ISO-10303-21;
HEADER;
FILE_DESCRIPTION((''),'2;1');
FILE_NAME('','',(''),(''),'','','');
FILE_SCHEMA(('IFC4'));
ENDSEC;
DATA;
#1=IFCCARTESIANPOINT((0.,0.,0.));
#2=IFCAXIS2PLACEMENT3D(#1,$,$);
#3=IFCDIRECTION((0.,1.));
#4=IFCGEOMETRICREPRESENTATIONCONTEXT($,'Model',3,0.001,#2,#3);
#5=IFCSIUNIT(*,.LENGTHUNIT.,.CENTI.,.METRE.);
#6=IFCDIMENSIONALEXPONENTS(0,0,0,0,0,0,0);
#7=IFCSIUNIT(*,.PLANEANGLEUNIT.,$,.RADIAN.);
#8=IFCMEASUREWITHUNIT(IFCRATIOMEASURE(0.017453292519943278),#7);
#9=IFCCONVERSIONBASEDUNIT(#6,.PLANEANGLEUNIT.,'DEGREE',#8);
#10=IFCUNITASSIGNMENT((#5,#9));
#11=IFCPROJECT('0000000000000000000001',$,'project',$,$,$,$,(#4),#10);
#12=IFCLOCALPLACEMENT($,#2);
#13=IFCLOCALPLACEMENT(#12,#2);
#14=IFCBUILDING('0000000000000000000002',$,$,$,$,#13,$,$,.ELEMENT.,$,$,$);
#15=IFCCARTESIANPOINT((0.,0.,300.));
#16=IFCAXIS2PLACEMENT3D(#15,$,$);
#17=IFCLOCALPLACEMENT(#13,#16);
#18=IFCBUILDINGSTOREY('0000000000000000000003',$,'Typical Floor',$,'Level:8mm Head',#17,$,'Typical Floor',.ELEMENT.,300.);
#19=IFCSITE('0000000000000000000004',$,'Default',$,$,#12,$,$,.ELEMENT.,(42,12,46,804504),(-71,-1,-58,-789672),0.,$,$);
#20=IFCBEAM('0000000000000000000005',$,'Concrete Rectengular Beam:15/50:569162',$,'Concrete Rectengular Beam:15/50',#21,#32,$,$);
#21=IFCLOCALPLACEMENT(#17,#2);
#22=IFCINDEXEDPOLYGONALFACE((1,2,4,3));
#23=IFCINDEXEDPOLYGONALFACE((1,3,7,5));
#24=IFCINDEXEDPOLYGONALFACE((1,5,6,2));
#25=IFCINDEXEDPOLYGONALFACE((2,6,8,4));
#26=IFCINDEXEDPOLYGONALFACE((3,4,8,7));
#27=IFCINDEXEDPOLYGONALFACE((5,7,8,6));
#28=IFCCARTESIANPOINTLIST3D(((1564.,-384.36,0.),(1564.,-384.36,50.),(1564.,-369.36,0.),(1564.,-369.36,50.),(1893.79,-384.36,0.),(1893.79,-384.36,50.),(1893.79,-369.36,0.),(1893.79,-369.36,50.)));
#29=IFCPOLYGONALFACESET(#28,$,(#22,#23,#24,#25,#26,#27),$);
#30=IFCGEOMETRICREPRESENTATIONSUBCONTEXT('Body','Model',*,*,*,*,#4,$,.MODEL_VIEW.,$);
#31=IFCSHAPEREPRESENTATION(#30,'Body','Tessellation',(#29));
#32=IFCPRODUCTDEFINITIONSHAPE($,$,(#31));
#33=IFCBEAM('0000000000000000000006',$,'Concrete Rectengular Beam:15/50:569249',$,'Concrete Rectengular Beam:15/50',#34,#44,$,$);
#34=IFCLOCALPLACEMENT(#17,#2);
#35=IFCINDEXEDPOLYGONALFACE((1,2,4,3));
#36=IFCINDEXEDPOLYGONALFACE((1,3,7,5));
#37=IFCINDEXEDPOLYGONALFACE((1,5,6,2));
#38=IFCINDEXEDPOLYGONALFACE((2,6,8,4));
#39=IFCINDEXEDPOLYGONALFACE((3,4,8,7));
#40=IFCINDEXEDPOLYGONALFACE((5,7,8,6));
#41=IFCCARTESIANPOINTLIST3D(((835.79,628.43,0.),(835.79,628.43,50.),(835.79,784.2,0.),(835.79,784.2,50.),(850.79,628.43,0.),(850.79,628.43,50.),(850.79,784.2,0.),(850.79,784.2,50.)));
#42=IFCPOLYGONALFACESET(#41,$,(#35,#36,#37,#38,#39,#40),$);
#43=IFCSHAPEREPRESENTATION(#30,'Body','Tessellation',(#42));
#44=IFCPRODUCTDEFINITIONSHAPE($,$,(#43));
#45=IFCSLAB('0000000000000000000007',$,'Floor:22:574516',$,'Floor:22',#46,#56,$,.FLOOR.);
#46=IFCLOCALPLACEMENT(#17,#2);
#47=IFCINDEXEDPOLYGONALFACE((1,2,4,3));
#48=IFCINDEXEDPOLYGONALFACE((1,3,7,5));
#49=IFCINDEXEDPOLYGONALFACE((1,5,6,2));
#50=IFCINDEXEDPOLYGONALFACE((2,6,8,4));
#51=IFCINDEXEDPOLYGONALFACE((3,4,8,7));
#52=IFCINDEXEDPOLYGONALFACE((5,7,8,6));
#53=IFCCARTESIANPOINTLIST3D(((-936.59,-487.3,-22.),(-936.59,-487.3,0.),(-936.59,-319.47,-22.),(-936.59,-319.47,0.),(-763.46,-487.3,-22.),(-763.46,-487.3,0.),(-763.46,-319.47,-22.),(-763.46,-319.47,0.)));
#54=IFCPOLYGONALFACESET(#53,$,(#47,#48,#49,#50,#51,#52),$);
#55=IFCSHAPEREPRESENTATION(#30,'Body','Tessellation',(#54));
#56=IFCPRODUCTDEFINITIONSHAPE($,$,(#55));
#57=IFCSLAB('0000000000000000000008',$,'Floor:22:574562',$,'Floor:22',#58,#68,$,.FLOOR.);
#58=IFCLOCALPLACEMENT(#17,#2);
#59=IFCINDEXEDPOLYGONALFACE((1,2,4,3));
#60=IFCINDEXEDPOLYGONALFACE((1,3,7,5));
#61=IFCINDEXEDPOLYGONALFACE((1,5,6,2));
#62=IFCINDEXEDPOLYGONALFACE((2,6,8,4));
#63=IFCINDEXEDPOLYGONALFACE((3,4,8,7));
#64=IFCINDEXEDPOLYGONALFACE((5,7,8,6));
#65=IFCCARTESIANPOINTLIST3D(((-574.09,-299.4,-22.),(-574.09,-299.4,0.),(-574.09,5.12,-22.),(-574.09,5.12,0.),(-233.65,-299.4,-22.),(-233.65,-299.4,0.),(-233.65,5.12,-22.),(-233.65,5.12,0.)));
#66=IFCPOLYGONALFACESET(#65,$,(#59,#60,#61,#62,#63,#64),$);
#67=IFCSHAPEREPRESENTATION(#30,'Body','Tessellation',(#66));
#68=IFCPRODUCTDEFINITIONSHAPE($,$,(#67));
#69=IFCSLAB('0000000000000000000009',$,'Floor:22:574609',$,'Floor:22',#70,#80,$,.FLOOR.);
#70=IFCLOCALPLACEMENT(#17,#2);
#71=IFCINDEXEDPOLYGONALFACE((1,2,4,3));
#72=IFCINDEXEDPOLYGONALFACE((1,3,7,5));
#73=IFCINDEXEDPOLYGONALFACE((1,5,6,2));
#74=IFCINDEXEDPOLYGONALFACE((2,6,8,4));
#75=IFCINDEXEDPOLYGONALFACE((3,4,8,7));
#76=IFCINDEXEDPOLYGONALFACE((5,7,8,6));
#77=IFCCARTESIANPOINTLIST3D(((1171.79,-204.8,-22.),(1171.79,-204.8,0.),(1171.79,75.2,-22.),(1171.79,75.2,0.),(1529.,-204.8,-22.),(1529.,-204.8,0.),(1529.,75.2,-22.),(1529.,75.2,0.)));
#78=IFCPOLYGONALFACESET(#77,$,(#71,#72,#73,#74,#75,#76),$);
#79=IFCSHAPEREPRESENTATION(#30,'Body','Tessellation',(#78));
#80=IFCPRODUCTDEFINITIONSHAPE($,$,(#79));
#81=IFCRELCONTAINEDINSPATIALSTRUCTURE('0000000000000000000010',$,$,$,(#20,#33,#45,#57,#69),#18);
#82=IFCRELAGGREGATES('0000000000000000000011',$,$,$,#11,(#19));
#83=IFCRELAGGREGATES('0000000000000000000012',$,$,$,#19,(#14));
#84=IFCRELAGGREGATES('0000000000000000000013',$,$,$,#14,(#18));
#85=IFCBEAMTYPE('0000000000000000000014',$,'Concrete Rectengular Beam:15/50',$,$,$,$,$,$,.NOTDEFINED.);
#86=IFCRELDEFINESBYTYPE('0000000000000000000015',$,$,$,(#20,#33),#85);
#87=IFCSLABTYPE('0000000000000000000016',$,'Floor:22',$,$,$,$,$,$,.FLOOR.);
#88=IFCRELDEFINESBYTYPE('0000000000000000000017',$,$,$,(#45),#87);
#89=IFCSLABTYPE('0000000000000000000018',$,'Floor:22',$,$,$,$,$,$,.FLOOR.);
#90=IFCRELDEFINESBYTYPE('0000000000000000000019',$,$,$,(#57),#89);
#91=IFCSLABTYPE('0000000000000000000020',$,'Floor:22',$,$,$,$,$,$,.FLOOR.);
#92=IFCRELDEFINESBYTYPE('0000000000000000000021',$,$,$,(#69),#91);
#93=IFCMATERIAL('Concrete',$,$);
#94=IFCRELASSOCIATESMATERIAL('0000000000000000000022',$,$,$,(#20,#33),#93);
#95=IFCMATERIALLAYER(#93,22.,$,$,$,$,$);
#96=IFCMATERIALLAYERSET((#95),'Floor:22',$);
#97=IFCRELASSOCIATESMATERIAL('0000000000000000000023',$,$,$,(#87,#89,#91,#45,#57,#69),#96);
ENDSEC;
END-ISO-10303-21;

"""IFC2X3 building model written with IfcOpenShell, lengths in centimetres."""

from ifc_helpers import new_model, entity, si_unit, converted_unit, direction, frame, frame_2d, origin, origin_2d_with_axis, place, context, subcontext, project, spatial, rectangle, extrude, material, layer, layer_set, layer_usage, type_object, element, save


model = new_model("IFC2X3")

# Units and contexts
model_context = context("Model", 3, precision=0.001, world=origin(), true_north=direction((0.0, 1.0)))
body_context = subcontext(model_context, "Body", "Model", "MODEL_VIEW")
ifc_project = project(units=[si_unit("LENGTHUNIT", "METRE", prefix="CENTI"), converted_unit("PLANEANGLEUNIT", "DEGREE", entity("IfcRatioMeasure", 0.017453292519943278), si_unit("PLANEANGLEUNIT", "RADIAN"), dimensions=[0, 0, 0, 0, 0, 0, 0])], contexts=[model_context])

# Site, building, storey
site_placement = place(None, origin())
site = spatial("IfcSite", under=ifc_project, at=site_placement, Name="Default", CompositionType="ELEMENT", RefLatitude=(42, 12, 46, 804504), RefLongitude=(-71, -1, -58, -789672), RefElevation=0.0)
building_placement = place(site_placement, origin())
building = spatial("IfcBuilding", under=site, at=building_placement, CompositionType="ELEMENT")
storey_placement = place(building_placement, frame((0.0, 0.0, 300.0)))
storey = spatial("IfcBuildingStorey", under=building, at=storey_placement, Name="Typical Floor", ObjectType="Level:8mm Head", LongName="Typical Floor", CompositionType="ELEMENT", Elevation=300.0)

# Beams
ifc_material = material(Name="Concrete")
beam_type_1 = type_object("IfcBeamType", Name="Concrete Rectengular Beam:15/50", PredefinedType="NOTDEFINED")
beam_1_placement = place(storey_placement, frame((1564.0, -376.86, 0.0)))
element("IfcBeam", 1, at=beam_1_placement, inside=storey, type_object=beam_type_1, material=ifc_material, Name="Concrete Rectengular Beam:15/50:569162", ObjectType="Concrete Rectengular Beam:15/50", context=body_context, shape_type="SweptSolid", body=[
    extrude(rectangle(XDim=50.0, YDim=15.0, at=frame_2d((0.0, 0.0), x_axis=(1.0, 0.0))), frame((0.0, 0.0, 25.0), z_axis=(1.0, 0.0, 0.0), x_axis=(0.0, 0.0, -1.0)), (0.0, 0.0, 1.0), 329.8),
])
beam_2_placement = place(storey_placement, frame((843.29, 628.43, 0.0), z_axis=(0.0, 0.0, 1.0), x_axis=(0.0, 1.0, 0.0)))
element("IfcBeam", 2, at=beam_2_placement, inside=storey, type_object=beam_type_1, material=ifc_material, Name="Concrete Rectengular Beam:15/50:569249", ObjectType="Concrete Rectengular Beam:15/50", context=body_context, shape_type="SweptSolid", body=[
    extrude(rectangle(XDim=50.0, YDim=15.0, at=frame_2d((0.0, 0.0), x_axis=(1.0, 0.0))), frame((0.0, 0.0, 25.0), z_axis=(1.0, 0.0, 0.0), x_axis=(0.0, 0.0, -1.0)), (0.0, 0.0, 1.0), 155.77),
])

# Slabs
ifc_layer = layer(ifc_material, 22.0)
ifc_layer_set = layer_set([ifc_layer], Name="Floor:22")
ifc_layer_usage_1 = layer_usage(ifc_layer_set, "AXIS3", "POSITIVE", 0.0)
slab_type_1 = type_object("IfcSlabType", Name="Floor:22", PredefinedType="FLOOR", material=ifc_layer_set)
slab_1_placement = place(storey_placement, origin())
element("IfcSlab", 3, at=slab_1_placement, inside=storey, type_object=slab_type_1, material=ifc_layer_usage_1, Name="Floor:22:574516", ObjectType="Floor:22", PredefinedType="FLOOR", context=body_context, shape_type="SweptSolid", body=[
    extrude(rectangle(XDim=167.82, YDim=173.13, at=frame_2d((0.0, 0.0), x_axis=(1.0, 0.0))), frame((-850.03, -403.39, 0.0), z_axis=(0.0, 0.0, -1.0), x_axis=(0.0, 1.0, 0.0)), (0.0, 0.0, 1.0), 22.0),
])
ifc_layer_usage_2 = layer_usage(ifc_layer_set, "AXIS3", "POSITIVE", 0.0)
slab_type_2 = type_object("IfcSlabType", Name="Floor:22", PredefinedType="FLOOR", material=ifc_layer_set)
slab_2_placement = place(storey_placement, origin())
element("IfcSlab", 4, at=slab_2_placement, inside=storey, type_object=slab_type_2, material=ifc_layer_usage_2, Name="Floor:22:574562", ObjectType="Floor:22", PredefinedType="FLOOR", context=body_context, shape_type="SweptSolid", body=[
    extrude(rectangle(XDim=304.52, YDim=340.44, at=frame_2d((0.0, 0.0), x_axis=(1.0, 0.0))), frame((-403.87, -147.14, 0.0), z_axis=(0.0, 0.0, -1.0), x_axis=(0.0, 1.0, 0.0)), (0.0, 0.0, 1.0), 22.0),
])
ifc_layer_usage_3 = layer_usage(ifc_layer_set, "AXIS3", "POSITIVE", 0.0)
slab_type_3 = type_object("IfcSlabType", Name="Floor:22", PredefinedType="FLOOR", material=ifc_layer_set)
slab_3_placement = place(storey_placement, origin())
element("IfcSlab", 5, at=slab_3_placement, inside=storey, type_object=slab_type_3, material=ifc_layer_usage_3, Name="Floor:22:574609", ObjectType="Floor:22", PredefinedType="FLOOR", context=body_context, shape_type="SweptSolid", body=[
    extrude(rectangle(XDim=280.0, YDim=357.2, at=origin_2d_with_axis()), frame((1350.39, -64.8, 0.0), z_axis=(0.0, 0.0, -1.0), x_axis=(0.0, 1.0, 0.0)), (0.0, 0.0, 1.0), 22.0),
])

save(model, "model.ifc")
